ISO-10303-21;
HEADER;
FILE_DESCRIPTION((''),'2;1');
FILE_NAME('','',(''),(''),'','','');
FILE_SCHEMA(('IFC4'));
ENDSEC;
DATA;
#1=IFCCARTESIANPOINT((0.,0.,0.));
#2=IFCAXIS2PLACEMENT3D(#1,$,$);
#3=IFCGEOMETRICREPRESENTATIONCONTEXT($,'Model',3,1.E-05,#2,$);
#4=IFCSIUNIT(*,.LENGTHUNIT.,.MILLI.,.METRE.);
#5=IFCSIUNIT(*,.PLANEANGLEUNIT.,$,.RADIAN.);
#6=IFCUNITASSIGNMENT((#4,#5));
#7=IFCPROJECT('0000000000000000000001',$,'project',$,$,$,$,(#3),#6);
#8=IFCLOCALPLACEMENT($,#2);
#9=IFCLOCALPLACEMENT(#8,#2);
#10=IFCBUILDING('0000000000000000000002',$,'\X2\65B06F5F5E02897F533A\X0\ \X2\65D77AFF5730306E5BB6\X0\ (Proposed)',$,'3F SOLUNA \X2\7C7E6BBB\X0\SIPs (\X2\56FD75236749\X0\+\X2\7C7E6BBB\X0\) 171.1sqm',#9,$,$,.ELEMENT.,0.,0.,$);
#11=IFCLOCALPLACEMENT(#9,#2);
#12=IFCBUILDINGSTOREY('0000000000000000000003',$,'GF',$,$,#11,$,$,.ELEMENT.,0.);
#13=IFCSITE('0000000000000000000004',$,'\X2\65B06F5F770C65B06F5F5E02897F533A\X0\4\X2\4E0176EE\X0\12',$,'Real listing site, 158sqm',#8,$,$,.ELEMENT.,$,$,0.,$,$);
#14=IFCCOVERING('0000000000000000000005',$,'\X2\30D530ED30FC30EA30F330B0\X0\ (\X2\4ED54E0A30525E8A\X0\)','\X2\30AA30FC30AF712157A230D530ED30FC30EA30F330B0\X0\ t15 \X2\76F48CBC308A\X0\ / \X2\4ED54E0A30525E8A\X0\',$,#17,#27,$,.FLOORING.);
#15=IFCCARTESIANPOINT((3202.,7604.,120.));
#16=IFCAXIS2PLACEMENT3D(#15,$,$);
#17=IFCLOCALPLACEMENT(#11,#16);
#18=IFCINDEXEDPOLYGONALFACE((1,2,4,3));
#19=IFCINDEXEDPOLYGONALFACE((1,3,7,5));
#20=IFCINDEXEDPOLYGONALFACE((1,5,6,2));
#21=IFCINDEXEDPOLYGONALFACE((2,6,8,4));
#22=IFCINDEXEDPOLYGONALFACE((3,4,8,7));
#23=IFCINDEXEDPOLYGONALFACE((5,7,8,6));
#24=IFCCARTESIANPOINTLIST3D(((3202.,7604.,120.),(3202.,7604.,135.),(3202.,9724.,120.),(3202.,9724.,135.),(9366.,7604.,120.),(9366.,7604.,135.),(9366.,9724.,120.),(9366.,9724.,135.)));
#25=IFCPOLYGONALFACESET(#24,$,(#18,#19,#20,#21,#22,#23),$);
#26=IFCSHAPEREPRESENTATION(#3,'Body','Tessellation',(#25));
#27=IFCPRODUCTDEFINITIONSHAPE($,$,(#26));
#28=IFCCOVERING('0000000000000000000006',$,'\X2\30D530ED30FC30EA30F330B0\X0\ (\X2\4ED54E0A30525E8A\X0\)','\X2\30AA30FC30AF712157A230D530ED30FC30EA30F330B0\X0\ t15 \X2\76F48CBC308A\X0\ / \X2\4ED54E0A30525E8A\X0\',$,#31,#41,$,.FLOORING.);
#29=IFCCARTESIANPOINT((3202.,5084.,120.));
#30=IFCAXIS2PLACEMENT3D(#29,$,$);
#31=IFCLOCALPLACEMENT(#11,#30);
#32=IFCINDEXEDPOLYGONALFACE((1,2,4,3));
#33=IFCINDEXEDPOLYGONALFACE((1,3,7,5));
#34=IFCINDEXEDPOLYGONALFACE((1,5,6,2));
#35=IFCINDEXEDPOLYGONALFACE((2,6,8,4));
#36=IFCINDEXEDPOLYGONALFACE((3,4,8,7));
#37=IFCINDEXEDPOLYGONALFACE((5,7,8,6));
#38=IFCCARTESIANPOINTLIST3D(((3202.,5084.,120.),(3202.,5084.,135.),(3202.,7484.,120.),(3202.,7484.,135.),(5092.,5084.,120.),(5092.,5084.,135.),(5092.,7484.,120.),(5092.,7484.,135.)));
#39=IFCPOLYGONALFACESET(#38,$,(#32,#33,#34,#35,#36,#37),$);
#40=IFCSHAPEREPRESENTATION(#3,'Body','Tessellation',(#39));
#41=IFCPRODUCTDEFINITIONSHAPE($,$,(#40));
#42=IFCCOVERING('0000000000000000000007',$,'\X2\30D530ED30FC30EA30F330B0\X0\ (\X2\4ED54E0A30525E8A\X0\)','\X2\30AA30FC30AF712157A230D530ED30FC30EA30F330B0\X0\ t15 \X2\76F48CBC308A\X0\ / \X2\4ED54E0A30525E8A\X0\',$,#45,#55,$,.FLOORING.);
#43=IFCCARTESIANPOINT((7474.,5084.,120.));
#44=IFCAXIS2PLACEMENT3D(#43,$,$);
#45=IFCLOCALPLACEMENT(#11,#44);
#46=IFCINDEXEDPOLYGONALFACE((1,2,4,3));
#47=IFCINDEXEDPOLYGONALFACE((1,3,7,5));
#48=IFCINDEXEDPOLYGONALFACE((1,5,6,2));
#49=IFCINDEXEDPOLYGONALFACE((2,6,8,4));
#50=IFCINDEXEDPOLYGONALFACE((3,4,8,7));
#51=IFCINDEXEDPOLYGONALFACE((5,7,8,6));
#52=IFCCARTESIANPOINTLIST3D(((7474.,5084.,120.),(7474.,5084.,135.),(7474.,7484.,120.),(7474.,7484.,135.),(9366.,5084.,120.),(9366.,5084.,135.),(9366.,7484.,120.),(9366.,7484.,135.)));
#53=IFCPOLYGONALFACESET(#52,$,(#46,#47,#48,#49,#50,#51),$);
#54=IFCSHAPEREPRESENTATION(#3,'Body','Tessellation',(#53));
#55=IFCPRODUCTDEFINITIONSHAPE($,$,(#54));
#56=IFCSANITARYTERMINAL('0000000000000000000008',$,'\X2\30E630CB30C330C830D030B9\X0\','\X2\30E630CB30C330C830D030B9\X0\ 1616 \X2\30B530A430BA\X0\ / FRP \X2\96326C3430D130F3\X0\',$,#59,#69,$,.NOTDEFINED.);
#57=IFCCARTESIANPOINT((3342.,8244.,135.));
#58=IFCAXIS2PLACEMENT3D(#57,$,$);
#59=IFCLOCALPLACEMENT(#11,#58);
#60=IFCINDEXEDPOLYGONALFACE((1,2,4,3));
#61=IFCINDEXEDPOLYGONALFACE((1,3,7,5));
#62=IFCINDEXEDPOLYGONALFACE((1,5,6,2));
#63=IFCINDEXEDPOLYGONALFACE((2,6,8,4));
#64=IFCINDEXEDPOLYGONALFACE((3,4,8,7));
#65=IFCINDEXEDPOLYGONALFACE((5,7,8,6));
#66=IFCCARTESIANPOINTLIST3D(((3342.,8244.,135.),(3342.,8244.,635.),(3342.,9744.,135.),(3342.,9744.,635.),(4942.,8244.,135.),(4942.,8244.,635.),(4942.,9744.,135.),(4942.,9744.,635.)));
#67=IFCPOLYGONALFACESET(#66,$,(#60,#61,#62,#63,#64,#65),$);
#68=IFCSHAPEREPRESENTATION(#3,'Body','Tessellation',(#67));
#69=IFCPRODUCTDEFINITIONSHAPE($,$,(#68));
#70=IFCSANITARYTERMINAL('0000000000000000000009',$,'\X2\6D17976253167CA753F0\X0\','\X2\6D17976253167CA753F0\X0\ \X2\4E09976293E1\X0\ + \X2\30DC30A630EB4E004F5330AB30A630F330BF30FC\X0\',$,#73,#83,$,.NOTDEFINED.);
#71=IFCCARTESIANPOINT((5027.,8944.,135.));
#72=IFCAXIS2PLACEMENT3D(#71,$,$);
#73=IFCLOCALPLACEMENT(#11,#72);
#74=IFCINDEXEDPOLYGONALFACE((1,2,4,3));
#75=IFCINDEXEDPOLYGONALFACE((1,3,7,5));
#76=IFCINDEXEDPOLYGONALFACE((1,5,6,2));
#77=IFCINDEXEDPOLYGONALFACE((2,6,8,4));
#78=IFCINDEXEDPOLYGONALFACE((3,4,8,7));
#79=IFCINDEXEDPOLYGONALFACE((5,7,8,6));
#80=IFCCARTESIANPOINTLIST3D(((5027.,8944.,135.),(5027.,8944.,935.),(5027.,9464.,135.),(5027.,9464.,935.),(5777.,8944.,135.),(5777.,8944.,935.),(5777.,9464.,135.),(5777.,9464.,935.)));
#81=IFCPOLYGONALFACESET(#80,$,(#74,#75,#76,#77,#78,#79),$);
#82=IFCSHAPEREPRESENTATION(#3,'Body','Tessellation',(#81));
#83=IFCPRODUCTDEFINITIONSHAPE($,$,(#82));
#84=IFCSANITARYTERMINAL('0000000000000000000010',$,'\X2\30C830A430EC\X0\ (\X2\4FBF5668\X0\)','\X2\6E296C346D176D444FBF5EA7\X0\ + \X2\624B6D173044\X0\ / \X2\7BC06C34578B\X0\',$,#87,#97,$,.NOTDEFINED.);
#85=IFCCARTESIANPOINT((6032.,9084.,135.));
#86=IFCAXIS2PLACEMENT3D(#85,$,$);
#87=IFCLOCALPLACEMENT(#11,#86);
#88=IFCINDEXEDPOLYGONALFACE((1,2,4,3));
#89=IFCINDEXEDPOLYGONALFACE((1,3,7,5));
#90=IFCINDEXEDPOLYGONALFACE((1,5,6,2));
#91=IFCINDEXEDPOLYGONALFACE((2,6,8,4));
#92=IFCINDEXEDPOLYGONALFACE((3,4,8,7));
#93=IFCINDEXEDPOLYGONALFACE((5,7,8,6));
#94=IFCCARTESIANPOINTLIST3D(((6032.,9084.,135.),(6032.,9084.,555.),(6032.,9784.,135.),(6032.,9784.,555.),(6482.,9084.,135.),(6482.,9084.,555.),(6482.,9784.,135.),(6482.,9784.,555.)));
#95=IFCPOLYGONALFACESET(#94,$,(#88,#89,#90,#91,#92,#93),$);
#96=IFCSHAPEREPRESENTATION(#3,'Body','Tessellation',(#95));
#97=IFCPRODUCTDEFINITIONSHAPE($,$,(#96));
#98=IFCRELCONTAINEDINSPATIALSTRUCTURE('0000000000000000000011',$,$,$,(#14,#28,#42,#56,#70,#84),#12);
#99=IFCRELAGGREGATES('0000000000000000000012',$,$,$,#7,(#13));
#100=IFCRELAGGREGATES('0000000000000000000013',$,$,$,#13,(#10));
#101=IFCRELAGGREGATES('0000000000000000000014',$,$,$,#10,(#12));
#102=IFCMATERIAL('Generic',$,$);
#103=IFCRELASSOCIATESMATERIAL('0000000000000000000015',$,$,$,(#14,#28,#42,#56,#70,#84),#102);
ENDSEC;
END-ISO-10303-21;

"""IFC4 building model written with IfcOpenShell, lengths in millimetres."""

from ifc_helpers import new_model, si_unit, frame, frame_2d, origin, place, context, project, spatial, rectangle, extrude, material, element, save


model = new_model("IFC4")

# Units and contexts
model_context = context("Model", 3, precision=1e-05, world=origin())
ifc_project = project(units=[si_unit("LENGTHUNIT", "METRE", prefix="MILLI"), si_unit("PLANEANGLEUNIT", "RADIAN")], contexts=[model_context])

# Site, building, storey
site_placement = place(None, origin())
site = spatial("IfcSite", under=ifc_project, at=site_placement, Name="新潟県新潟市西区4丁目12", ObjectType="Real listing site, 158sqm", CompositionType="ELEMENT", RefElevation=0.0)
building_placement = place(site_placement, origin())
building = spatial("IfcBuilding", under=site, at=building_placement, Name="新潟市西区 旗竿地の家 (Proposed)", ObjectType="3F SOLUNA 籾殻SIPs (国産杉+籾殻) 171.1sqm", CompositionType="ELEMENT", ElevationOfRefHeight=0.0, ElevationOfTerrain=0.0)
storey_placement = place(building_placement, origin())
storey = spatial("IfcBuildingStorey", under=building, at=storey_placement, Name="GF", CompositionType="ELEMENT", Elevation=0.0)

# Coverings
ifc_material_1 = material(Name="Generic")
covering_1_placement = place(storey_placement, frame((3202.0, 7604.0, 120.0)))
element("IfcCovering", 1, at=covering_1_placement, inside=storey, material=ifc_material_1, Name="フローリング (仕上げ床)", Description="オーク無垢フローリング t15 直貼り / 仕上げ床", PredefinedType="FLOORING", context=model_context, shape_type="SweptSolid", body=[
    extrude(rectangle(XDim=6164.0, YDim=2120.0, at=frame_2d((3082.0, 1060.0))), frame((3202.0, 7604.0, 120.0)), (0.0, 0.0, 1.0), 15.0),
])
covering_2_placement = place(storey_placement, frame((3202.0, 5084.0, 120.0)))
element("IfcCovering", 2, at=covering_2_placement, inside=storey, material=ifc_material_1, Name="フローリング (仕上げ床)", Description="オーク無垢フローリング t15 直貼り / 仕上げ床", PredefinedType="FLOORING", context=model_context, shape_type="SweptSolid", body=[
    extrude(rectangle(XDim=1890.0, YDim=2400.0, at=frame_2d((945.0, 1200.0))), frame((3202.0, 5084.0, 120.0)), (0.0, 0.0, 1.0), 15.0),
])
covering_3_placement = place(storey_placement, frame((7474.0, 5084.0, 120.0)))
element("IfcCovering", 3, at=covering_3_placement, inside=storey, material=ifc_material_1, Name="フローリング (仕上げ床)", Description="オーク無垢フローリング t15 直貼り / 仕上げ床", PredefinedType="FLOORING", context=model_context, shape_type="SweptSolid", body=[
    extrude(rectangle(XDim=1892.0, YDim=2400.0, at=frame_2d((946.0, 1200.0))), frame((7474.0, 5084.0, 120.0)), (0.0, 0.0, 1.0), 15.0),
])

# Sanitary terminals
sanitary_terminal_1_placement = place(storey_placement, frame((3342.0, 8244.0, 135.0)))
element("IfcSanitaryTerminal", 4, at=sanitary_terminal_1_placement, inside=storey, material=ifc_material_1, Name="ユニットバス", Description="ユニットバス 1616 サイズ / FRP 防水パン", PredefinedType="NOTDEFINED", context=model_context, shape_type="SweptSolid", body=[
    extrude(rectangle(XDim=1600.0, YDim=1500.0, at=frame_2d((800.0, 750.0))), frame((3342.0, 8244.0, 135.0)), (0.0, 0.0, 1.0), 500.0),
])
sanitary_terminal_2_placement = place(storey_placement, frame((5027.0, 8944.0, 135.0)))
element("IfcSanitaryTerminal", 5, at=sanitary_terminal_2_placement, inside=storey, material=ifc_material_1, Name="洗面化粧台", Description="洗面化粧台 三面鏡 + ボウル一体カウンター", PredefinedType="NOTDEFINED", context=model_context, shape_type="SweptSolid", body=[
    extrude(rectangle(XDim=750.0, YDim=520.0, at=frame_2d((375.0, 260.0))), frame((5027.0, 8944.0, 135.0)), (0.0, 0.0, 1.0), 800.0),
])
sanitary_terminal_3_placement = place(storey_placement, frame((6032.0, 9084.0, 135.0)))
element("IfcSanitaryTerminal", 6, at=sanitary_terminal_3_placement, inside=storey, material=ifc_material_1, Name="トイレ (便器)", Description="温水洗浄便座 + 手洗い / 節水型", PredefinedType="NOTDEFINED", context=model_context, shape_type="SweptSolid", body=[
    extrude(rectangle(XDim=450.0, YDim=700.0, at=frame_2d((225.0, 350.0))), frame((6032.0, 9084.0, 135.0)), (0.0, 0.0, 1.0), 420.0),
])

save(model, "model.ifc")
